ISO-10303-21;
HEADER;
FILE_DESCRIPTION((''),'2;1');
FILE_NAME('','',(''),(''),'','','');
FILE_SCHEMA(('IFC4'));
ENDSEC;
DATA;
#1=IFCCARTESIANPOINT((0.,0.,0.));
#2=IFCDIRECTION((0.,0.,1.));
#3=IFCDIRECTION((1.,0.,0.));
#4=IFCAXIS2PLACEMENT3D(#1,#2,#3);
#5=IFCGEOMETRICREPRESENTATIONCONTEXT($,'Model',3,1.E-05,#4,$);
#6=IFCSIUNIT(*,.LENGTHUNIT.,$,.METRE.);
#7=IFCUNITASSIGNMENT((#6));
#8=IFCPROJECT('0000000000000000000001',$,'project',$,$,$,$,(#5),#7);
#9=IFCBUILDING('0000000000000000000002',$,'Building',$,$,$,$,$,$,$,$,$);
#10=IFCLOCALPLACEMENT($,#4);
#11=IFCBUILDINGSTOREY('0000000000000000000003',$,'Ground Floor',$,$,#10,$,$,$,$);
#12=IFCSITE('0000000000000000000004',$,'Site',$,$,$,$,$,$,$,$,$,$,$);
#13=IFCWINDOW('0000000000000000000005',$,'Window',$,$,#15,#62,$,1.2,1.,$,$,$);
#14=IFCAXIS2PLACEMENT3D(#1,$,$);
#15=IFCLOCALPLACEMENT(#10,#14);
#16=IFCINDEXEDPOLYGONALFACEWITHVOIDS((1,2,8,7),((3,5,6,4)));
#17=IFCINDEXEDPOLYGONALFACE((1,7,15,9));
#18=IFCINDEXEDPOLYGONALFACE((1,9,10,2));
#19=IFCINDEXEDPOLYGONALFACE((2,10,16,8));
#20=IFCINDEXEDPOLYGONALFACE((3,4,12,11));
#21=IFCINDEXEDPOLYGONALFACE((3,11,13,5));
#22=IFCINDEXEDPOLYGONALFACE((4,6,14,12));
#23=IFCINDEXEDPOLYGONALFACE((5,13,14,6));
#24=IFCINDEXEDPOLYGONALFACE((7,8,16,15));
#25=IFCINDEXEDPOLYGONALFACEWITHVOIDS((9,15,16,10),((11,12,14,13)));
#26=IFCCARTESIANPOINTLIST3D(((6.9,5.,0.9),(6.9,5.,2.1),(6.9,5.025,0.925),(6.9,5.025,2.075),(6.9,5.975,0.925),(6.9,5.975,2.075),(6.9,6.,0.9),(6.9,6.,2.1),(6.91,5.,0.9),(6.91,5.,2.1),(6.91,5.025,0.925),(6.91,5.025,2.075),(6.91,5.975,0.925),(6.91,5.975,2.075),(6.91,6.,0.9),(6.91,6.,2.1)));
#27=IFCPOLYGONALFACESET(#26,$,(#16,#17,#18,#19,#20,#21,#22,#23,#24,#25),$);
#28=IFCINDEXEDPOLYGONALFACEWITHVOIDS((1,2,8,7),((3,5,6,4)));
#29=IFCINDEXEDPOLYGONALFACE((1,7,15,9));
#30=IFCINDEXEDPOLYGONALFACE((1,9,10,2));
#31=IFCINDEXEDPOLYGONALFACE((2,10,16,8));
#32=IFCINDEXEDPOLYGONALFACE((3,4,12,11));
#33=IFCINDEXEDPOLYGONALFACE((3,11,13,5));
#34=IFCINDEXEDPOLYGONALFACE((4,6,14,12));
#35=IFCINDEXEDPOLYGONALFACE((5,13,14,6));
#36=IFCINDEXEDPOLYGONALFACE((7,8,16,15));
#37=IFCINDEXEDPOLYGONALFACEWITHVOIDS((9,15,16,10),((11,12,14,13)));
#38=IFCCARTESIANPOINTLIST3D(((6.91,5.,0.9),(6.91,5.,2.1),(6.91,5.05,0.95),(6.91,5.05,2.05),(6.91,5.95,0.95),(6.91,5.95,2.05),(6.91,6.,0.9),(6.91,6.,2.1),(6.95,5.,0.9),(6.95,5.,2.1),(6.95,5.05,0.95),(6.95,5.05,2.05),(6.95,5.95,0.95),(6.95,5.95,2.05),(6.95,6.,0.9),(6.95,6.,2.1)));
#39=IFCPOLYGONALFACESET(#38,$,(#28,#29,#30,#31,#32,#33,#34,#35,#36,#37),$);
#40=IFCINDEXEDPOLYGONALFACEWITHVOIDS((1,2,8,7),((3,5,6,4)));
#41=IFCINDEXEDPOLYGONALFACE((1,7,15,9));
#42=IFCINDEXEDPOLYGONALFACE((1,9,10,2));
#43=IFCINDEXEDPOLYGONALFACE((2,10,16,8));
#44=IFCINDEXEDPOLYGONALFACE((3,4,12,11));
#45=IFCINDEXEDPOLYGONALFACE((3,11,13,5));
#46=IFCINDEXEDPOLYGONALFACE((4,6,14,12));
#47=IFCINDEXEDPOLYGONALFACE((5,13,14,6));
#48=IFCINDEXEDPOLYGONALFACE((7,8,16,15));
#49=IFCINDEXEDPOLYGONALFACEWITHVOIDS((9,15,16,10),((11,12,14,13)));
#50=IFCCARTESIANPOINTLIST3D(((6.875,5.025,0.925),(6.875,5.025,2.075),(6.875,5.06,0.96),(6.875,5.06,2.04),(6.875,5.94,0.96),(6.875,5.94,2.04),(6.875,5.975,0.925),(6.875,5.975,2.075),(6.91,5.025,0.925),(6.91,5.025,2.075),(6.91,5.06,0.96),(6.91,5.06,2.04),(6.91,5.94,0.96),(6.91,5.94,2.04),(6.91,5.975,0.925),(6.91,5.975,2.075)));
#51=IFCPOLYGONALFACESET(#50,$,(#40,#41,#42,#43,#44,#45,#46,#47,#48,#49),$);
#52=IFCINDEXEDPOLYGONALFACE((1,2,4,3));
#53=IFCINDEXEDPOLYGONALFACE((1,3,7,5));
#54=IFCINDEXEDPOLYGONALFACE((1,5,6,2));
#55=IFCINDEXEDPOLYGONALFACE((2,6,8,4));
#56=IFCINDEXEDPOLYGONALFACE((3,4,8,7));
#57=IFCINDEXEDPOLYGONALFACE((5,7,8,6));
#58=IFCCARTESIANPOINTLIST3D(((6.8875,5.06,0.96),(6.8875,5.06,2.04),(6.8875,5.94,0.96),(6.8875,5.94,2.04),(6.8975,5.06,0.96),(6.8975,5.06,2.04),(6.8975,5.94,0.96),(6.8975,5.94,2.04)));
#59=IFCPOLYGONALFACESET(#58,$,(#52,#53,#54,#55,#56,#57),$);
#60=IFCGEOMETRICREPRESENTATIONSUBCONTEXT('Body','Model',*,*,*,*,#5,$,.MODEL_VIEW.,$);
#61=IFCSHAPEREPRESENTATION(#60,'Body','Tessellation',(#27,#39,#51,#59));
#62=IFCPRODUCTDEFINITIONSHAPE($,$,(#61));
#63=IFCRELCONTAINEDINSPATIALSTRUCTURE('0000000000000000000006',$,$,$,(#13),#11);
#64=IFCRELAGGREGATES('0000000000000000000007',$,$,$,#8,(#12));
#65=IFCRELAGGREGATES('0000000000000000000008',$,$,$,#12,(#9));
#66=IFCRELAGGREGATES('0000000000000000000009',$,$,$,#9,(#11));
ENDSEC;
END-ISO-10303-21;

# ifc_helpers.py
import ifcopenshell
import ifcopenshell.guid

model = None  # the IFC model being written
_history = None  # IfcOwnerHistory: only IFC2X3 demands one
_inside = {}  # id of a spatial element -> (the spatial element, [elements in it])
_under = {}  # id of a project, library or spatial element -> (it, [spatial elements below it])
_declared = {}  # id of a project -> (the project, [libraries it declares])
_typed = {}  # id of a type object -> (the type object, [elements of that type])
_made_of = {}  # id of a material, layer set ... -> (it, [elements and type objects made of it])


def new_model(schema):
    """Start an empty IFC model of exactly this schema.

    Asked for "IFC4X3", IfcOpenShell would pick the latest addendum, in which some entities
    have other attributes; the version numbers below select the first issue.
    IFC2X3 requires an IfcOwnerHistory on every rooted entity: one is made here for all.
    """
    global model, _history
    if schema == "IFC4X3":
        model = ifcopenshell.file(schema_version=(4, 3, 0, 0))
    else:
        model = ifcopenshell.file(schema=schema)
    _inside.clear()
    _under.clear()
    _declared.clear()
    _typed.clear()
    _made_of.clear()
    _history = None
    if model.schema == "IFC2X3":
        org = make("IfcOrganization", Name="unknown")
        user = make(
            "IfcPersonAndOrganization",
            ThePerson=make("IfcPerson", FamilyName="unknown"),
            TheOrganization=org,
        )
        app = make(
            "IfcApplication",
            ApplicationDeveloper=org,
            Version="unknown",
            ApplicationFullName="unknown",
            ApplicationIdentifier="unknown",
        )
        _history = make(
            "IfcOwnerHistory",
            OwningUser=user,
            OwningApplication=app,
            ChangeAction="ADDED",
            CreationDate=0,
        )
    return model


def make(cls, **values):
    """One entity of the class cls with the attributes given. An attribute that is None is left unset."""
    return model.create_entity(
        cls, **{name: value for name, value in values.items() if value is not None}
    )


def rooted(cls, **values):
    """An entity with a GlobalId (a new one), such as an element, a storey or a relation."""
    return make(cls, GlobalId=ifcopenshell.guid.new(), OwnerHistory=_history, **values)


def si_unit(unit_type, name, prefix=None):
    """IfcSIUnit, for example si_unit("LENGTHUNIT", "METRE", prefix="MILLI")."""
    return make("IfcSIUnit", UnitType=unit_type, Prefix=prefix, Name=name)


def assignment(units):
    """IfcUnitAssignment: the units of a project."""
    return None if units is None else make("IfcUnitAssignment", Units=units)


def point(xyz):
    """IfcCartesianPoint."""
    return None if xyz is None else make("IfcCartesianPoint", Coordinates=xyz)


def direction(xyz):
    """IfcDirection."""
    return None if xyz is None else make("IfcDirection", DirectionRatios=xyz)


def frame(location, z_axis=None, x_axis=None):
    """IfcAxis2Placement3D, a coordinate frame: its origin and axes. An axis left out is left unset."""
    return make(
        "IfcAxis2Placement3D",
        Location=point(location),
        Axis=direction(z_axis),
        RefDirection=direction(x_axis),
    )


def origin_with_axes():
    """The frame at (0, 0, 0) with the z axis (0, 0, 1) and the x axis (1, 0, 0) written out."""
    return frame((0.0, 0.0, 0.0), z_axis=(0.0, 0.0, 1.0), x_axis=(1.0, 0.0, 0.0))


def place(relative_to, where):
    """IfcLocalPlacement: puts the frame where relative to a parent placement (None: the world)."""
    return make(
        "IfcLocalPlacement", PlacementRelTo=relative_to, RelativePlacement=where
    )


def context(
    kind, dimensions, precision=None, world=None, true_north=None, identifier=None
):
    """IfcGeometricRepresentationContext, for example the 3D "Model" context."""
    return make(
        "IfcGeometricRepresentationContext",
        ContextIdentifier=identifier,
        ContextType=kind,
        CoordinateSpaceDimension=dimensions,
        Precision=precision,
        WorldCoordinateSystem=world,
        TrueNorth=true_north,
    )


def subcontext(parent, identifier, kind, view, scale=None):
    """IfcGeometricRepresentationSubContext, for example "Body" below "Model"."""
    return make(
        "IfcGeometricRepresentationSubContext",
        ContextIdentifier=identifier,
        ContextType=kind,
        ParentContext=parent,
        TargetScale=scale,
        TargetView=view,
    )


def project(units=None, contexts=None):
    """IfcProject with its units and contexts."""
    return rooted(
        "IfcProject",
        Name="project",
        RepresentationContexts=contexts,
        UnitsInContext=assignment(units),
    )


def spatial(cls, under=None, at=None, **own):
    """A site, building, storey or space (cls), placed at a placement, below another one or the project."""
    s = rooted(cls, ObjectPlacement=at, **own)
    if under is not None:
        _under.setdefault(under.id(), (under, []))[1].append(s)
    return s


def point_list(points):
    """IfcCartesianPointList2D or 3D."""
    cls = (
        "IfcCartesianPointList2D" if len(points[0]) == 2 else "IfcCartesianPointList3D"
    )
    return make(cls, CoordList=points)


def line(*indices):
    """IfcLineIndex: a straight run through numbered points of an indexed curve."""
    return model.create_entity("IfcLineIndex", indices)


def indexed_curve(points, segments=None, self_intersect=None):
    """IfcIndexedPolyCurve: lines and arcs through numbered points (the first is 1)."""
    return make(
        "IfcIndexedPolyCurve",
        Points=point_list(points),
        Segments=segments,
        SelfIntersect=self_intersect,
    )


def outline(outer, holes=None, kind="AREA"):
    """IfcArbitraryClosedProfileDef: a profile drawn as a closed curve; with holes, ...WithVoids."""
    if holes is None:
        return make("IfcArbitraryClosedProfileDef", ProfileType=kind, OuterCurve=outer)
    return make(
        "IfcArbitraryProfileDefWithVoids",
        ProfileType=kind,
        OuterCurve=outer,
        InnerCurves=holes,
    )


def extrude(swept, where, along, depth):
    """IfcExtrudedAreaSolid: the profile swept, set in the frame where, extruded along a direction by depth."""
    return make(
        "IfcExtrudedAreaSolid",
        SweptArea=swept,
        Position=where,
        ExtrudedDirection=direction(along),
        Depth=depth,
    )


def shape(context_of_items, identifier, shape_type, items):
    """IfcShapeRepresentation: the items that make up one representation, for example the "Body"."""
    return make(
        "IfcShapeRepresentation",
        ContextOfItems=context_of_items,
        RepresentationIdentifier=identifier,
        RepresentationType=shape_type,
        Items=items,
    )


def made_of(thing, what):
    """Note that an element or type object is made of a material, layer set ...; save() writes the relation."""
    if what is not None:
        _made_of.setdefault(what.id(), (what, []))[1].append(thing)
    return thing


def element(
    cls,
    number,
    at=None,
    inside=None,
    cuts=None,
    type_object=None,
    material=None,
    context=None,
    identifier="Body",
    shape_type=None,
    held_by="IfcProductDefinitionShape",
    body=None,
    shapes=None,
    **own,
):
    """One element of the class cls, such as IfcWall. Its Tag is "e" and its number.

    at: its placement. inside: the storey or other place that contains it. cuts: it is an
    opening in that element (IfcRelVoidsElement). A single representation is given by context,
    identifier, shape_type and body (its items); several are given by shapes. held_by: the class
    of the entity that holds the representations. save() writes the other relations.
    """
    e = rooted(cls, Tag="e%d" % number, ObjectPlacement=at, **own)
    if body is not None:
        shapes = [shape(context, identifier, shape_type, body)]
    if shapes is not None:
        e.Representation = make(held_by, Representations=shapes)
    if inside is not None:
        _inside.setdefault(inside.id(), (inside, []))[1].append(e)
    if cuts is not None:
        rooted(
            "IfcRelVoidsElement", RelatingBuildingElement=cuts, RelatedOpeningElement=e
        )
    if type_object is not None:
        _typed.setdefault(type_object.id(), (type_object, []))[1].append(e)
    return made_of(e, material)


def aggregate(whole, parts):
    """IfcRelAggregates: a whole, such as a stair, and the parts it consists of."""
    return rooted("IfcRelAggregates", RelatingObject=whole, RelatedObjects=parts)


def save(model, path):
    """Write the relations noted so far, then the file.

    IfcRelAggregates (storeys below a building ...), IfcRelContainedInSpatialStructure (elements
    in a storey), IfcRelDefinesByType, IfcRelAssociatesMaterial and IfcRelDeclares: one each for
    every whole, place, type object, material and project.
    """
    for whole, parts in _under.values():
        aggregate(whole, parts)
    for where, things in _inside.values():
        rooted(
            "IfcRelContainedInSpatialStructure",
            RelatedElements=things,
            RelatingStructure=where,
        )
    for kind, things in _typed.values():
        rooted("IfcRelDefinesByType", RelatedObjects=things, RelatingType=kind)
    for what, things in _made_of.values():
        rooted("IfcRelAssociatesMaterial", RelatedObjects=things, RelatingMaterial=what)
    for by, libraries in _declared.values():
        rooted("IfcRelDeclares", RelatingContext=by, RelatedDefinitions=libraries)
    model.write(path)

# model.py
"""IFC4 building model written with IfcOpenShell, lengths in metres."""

from ifc_helpers import new_model, si_unit, frame, origin_with_axes, place, context, subcontext, project, spatial, line, indexed_curve, outline, extrude, element, save


model = new_model("IFC4")

# Units and contexts
model_context = context("Model", 3, precision=1e-05, world=origin_with_axes())
body_context = subcontext(model_context, "Body", "Model", "MODEL_VIEW")
ifc_project = project(units=[si_unit("LENGTHUNIT", "METRE")], contexts=[model_context])

# Site, building, storey
site = spatial("IfcSite", under=ifc_project, Name="Site")
building = spatial("IfcBuilding", under=site, Name="Building")
storey_placement = place(None, origin_with_axes())
storey = spatial("IfcBuildingStorey", under=building, at=storey_placement, Name="Ground Floor")

# Window
window_1_placement = place(storey_placement, frame((7.0, 5.0, 0.9), z_axis=(0.0, 0.0, 1.0), x_axis=(0.0, 1.0, 0.0)))
element("IfcWindow", 1, at=window_1_placement, inside=storey, Name="Window", OverallHeight=1.2, OverallWidth=1.0, context=body_context, shape_type="SweptSolid", body=[
    extrude(outline(indexed_curve([(0.0, 0.0), (1.0, 0.0), (1.0, 1.2), (0.0, 1.2)], segments=[line(1, 2, 3, 4, 1)]), holes=[indexed_curve([(0.025, 0.025), (0.975, 0.025), (0.975, 1.175), (0.025, 1.175)], segments=[line(1, 2, 3, 4, 1)])]), frame((0.0, 0.09, 0.0), z_axis=(0.0, -1.0, 0.0), x_axis=(1.0, 0.0, 0.0)), (0.0, 0.0, -1.0), 0.01),
    extrude(outline(indexed_curve([(0.0, 0.0), (1.0, 0.0), (1.0, 1.2), (0.0, 1.2)], segments=[line(1, 2, 3, 4, 1)]), holes=[indexed_curve([(0.05, 0.05), (0.95, 0.05), (0.95, 1.15), (0.05, 1.15)], segments=[line(1, 2, 3, 4, 1)])]), frame((0.0, 0.05, 0.0), z_axis=(0.0, -1.0, 0.0), x_axis=(1.0, 0.0, 0.0)), (0.0, 0.0, -1.0), 0.04),
    extrude(outline(indexed_curve([(0.0, 0.0), (0.95, 0.0), (0.95, 1.15), (0.0, 1.15)], segments=[line(1, 2, 3, 4, 1)]), holes=[indexed_curve([(0.035, 0.035), (0.915, 0.035), (0.915, 1.115), (0.035, 1.115)], segments=[line(1, 2, 3, 4, 1)])]), frame((0.025, 0.09, 0.025), z_axis=(0.0, -1.0, 0.0), x_axis=(1.0, 0.0, 0.0)), (0.0, 0.0, -1.0), 0.035),
    extrude(outline(indexed_curve([(0.035, 0.035), (0.915, 0.035), (0.915, 1.115), (0.035, 1.115)], segments=[line(1, 2, 3, 4, 1)])), frame((0.025, 0.1025, 0.025), z_axis=(0.0, -1.0, 0.0), x_axis=(1.0, 0.0, 0.0)), (0.0, 0.0, -1.0), 0.01),
])

save(model, "model.ifc")
